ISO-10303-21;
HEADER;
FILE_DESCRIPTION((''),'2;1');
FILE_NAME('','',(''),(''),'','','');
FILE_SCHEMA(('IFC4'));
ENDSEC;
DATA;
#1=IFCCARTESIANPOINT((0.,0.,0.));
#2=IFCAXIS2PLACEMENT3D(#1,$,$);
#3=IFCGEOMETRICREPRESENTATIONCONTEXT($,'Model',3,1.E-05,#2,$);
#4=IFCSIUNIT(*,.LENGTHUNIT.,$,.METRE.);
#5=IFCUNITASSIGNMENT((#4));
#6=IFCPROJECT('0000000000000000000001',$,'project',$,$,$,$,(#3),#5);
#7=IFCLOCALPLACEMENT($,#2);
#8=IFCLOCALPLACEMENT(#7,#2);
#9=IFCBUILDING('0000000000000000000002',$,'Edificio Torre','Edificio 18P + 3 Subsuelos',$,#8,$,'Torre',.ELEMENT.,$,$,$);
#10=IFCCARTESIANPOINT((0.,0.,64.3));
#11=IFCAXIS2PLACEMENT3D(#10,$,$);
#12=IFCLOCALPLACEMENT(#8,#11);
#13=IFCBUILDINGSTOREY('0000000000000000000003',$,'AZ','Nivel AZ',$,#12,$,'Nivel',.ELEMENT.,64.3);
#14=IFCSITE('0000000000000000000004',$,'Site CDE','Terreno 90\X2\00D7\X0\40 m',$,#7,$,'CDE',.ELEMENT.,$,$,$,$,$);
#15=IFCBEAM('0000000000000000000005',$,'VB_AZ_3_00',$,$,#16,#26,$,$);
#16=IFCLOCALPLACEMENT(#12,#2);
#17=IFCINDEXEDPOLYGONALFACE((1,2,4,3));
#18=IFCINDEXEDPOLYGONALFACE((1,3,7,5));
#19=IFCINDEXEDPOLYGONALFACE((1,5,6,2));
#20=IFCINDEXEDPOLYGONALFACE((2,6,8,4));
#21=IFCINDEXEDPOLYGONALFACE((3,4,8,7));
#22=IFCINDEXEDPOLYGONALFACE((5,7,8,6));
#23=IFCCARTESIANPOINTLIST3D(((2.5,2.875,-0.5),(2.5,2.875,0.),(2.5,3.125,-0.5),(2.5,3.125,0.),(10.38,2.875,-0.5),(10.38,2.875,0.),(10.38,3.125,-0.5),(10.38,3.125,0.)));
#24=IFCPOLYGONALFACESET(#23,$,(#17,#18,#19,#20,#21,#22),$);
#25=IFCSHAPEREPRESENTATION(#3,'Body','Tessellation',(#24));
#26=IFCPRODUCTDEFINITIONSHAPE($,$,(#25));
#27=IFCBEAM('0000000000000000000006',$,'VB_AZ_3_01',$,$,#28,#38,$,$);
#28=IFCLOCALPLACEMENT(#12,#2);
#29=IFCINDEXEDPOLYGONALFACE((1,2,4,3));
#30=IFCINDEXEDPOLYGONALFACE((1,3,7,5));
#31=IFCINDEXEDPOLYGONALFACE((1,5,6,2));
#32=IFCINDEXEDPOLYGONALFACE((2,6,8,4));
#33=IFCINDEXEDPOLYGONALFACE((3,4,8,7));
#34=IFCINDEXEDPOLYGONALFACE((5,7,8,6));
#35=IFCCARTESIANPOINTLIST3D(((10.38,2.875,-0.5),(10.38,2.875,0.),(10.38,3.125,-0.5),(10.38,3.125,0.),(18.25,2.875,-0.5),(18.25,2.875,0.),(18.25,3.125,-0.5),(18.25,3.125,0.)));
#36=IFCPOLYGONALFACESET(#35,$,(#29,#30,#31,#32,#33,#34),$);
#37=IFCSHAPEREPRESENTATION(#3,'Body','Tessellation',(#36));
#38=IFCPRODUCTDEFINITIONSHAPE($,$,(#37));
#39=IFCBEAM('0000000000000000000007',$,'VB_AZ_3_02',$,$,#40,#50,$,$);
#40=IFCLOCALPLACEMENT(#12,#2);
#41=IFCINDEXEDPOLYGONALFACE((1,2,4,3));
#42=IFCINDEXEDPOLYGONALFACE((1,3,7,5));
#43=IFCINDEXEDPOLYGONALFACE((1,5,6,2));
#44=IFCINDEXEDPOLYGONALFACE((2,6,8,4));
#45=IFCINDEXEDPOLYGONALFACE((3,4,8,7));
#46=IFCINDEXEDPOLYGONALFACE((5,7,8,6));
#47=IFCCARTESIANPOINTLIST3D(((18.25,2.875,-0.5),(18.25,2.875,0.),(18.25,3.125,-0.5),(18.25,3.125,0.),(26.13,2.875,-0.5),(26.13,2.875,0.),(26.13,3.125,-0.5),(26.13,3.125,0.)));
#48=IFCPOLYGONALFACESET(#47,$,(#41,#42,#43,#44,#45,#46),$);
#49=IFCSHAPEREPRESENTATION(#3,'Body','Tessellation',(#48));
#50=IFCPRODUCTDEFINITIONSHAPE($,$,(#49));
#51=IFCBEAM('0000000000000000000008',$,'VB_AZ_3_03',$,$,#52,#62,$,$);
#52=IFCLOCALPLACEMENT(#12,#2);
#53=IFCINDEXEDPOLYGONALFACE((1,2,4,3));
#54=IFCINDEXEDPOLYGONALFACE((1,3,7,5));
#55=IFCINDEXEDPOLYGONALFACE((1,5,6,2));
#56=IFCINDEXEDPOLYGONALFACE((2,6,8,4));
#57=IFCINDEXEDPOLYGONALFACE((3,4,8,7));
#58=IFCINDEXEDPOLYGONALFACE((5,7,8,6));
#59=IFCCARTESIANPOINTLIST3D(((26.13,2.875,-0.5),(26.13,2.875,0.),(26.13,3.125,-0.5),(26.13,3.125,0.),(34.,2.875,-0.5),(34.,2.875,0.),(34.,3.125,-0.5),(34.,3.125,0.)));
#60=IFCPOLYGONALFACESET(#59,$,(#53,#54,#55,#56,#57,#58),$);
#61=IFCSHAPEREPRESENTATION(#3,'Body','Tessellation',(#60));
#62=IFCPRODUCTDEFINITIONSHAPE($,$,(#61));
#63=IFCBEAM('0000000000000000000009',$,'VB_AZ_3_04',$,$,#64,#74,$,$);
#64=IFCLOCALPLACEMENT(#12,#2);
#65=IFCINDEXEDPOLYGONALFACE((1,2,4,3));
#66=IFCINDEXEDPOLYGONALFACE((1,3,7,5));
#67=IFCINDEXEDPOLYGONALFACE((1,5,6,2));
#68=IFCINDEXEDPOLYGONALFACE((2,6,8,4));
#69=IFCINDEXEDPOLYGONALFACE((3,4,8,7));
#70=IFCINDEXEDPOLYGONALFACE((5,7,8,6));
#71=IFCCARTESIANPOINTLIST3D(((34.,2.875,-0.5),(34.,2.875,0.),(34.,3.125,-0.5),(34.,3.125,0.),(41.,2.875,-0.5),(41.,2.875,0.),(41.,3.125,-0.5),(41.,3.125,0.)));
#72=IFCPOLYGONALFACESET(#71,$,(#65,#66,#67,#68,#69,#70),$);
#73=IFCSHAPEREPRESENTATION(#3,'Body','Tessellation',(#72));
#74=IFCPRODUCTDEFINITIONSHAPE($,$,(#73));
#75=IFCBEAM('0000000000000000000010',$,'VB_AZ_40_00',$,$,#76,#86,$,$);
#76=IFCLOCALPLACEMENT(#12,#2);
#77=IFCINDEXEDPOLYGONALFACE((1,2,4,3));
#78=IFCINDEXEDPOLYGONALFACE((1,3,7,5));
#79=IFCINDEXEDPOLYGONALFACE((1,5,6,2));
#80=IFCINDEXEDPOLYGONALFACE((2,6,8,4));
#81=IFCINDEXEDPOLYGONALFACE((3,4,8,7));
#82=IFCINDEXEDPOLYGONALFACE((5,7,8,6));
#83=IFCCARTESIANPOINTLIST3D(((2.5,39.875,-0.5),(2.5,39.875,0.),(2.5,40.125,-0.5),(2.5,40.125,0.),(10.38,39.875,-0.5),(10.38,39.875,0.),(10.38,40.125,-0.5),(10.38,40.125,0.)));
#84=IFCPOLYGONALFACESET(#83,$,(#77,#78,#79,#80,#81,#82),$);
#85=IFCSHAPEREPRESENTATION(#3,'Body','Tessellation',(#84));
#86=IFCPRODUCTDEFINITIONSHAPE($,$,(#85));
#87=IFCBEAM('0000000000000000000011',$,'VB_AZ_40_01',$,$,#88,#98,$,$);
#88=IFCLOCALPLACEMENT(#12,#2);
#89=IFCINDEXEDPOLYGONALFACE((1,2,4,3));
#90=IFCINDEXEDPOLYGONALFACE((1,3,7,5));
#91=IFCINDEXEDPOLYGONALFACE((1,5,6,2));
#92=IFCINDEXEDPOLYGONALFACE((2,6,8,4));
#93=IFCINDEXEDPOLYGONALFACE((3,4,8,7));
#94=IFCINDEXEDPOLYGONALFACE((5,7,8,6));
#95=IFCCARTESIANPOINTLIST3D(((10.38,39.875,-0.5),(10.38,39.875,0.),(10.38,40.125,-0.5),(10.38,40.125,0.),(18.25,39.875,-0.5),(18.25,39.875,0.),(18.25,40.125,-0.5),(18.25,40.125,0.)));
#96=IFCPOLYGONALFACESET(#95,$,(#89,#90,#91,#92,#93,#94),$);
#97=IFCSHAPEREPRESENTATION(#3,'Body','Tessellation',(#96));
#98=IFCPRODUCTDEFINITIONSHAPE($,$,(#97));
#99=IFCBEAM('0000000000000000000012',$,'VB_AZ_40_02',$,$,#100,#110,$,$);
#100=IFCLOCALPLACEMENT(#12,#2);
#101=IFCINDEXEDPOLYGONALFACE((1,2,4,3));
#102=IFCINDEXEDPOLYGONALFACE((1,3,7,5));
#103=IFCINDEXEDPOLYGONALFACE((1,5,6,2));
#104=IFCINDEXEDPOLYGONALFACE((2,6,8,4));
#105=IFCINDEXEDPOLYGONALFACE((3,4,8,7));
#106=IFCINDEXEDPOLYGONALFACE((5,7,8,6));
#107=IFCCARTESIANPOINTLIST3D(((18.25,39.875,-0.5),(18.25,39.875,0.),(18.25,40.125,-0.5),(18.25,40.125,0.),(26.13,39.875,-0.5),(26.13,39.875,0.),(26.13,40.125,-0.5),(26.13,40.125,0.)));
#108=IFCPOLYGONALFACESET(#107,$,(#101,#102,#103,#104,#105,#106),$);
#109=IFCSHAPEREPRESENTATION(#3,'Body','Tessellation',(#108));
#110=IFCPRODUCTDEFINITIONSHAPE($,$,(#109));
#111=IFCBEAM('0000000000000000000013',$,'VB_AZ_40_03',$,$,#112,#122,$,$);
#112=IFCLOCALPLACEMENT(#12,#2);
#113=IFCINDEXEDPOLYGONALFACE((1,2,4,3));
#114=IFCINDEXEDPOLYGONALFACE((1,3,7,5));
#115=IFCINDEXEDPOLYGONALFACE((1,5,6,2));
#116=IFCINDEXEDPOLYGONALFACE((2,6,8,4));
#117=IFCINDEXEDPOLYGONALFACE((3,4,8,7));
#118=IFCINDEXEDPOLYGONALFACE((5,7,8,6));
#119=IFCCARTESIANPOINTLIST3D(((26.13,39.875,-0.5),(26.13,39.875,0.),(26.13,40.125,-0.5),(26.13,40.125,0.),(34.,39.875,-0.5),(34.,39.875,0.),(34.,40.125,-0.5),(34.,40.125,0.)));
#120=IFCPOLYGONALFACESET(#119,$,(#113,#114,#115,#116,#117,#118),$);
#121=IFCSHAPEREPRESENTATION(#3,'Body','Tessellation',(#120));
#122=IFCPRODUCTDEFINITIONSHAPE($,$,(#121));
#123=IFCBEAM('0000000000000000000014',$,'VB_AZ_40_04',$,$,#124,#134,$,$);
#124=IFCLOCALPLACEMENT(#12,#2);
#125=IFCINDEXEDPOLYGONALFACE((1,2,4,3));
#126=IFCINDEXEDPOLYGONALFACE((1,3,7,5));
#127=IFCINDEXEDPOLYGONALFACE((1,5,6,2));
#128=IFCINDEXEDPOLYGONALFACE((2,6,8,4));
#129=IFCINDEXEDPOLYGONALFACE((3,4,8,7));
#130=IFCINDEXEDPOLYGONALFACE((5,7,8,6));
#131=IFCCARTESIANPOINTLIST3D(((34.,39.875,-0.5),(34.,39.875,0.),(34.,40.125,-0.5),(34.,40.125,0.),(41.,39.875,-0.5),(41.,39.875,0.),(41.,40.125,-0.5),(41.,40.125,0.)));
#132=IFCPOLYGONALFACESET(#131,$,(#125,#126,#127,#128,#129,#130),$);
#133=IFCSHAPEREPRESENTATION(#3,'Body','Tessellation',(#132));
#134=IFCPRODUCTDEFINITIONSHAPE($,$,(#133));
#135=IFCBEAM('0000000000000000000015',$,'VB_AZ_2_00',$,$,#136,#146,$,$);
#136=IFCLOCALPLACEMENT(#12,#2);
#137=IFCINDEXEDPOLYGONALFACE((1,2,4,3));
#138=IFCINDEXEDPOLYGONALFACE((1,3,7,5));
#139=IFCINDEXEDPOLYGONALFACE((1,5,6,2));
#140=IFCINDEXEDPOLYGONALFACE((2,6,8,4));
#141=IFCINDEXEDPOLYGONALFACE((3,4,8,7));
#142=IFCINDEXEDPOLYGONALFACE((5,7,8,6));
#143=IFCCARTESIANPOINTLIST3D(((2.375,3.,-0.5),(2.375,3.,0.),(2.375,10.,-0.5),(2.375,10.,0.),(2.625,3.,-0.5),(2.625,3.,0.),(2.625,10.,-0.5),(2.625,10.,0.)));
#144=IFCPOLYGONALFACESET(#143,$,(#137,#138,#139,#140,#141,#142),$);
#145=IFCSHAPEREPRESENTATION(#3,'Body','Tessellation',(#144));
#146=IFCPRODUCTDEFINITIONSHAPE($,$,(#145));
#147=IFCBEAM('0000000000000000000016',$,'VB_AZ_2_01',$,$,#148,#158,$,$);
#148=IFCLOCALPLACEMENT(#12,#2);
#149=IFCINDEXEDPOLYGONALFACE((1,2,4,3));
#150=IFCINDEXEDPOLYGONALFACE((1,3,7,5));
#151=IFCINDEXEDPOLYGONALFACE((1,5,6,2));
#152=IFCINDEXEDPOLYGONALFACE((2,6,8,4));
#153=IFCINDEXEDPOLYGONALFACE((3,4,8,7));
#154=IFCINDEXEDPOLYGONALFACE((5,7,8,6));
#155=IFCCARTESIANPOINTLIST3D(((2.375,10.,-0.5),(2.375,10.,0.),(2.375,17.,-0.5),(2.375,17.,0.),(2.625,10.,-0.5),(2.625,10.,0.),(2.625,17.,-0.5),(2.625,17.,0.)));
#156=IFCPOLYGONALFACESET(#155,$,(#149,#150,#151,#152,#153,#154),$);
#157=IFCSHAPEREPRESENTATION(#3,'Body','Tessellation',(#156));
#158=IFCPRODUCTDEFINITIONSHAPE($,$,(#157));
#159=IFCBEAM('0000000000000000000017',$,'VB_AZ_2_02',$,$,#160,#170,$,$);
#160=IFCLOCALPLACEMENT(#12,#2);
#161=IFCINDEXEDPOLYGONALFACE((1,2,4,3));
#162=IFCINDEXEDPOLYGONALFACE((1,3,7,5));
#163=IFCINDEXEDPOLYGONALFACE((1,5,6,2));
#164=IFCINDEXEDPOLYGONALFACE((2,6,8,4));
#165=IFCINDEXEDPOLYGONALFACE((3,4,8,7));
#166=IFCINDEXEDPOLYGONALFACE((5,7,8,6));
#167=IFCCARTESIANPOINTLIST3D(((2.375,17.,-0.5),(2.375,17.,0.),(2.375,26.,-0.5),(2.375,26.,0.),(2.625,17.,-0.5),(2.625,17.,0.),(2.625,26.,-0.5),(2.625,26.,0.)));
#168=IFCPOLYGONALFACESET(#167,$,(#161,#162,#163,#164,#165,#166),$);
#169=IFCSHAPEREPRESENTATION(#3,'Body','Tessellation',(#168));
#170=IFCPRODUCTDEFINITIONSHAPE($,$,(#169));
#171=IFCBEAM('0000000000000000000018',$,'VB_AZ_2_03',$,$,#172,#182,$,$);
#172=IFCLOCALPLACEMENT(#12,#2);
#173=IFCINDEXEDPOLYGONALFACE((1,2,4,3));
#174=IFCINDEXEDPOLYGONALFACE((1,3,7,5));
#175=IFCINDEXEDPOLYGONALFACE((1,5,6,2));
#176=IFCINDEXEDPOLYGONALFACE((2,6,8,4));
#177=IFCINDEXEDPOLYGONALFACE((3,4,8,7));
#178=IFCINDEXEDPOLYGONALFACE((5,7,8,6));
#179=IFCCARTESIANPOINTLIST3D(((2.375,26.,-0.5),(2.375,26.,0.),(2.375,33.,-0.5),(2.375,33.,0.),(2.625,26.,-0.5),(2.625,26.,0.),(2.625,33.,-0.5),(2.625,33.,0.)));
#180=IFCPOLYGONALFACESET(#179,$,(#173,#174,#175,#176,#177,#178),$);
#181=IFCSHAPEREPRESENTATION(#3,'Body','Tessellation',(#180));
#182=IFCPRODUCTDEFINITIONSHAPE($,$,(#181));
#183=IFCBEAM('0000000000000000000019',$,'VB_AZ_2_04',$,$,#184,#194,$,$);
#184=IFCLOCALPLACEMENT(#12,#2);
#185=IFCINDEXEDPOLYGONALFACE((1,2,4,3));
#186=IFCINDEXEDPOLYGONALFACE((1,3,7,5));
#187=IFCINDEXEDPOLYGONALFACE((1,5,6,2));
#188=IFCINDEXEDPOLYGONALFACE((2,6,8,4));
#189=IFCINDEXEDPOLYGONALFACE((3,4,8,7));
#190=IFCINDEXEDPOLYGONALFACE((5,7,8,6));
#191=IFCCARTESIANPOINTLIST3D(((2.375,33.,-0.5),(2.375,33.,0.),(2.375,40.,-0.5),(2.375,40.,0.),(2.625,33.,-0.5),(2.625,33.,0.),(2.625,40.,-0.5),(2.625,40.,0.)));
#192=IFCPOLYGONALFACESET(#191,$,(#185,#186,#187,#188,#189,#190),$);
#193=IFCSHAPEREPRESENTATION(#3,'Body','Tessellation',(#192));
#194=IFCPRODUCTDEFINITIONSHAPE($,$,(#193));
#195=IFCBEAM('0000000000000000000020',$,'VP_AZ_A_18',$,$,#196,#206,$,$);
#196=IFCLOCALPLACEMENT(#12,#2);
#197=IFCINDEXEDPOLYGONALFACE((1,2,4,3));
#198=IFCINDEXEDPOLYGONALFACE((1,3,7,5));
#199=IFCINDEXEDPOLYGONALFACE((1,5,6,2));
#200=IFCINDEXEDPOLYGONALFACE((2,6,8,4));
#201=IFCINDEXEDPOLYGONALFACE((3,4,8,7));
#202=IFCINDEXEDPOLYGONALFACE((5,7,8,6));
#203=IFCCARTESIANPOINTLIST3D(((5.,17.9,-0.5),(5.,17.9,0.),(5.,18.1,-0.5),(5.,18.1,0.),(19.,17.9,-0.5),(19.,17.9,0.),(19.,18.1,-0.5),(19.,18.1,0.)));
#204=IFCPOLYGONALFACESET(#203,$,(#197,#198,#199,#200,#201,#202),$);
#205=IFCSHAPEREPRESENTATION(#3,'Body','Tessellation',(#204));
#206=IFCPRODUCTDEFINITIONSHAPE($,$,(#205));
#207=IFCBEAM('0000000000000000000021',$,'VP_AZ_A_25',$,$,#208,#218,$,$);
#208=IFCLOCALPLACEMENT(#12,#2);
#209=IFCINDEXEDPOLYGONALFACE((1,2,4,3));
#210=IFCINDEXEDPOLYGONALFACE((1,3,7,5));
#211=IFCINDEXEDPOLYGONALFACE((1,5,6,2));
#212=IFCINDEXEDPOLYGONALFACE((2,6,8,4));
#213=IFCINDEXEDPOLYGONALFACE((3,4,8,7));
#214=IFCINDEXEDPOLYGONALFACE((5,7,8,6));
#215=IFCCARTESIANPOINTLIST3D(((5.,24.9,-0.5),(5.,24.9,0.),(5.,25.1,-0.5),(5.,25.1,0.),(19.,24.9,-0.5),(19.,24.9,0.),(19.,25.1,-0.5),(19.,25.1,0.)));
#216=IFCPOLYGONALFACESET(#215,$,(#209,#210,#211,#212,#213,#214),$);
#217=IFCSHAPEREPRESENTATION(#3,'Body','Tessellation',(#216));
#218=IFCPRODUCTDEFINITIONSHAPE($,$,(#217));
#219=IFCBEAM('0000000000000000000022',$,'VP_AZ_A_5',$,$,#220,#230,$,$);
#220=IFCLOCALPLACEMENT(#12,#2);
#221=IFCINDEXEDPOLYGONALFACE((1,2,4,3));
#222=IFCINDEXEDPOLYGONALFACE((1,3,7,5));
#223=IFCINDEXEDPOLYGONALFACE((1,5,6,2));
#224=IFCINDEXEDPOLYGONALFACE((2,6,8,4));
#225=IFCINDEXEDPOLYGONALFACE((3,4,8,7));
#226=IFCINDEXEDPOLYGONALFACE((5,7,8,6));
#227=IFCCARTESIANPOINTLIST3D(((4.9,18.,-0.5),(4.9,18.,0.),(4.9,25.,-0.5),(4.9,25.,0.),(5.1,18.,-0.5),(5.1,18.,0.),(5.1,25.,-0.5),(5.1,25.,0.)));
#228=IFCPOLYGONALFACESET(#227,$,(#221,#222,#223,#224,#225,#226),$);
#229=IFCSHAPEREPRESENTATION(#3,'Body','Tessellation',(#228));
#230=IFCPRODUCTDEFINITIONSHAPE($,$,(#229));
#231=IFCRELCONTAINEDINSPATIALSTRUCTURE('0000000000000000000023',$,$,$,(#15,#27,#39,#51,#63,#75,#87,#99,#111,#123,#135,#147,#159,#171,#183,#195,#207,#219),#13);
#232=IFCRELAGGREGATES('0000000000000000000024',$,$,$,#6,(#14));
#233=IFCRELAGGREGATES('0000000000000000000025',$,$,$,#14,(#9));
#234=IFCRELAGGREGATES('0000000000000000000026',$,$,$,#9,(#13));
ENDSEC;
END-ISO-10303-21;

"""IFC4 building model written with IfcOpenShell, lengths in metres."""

from ifc_helpers import new_model, si_unit, frame, origin, origin_2d, place, context, project, spatial, rectangle, extrude, element, save


model = new_model("IFC4")

# Units and contexts
model_context = context("Model", 3, precision=1e-05, world=origin())
ifc_project = project(units=[si_unit("LENGTHUNIT", "METRE")], contexts=[model_context])

# Site, building, storey
site_placement = place(None, origin())
site = spatial("IfcSite", under=ifc_project, at=site_placement, Name="Site CDE", Description="Terreno 90×40 m", LongName="CDE", CompositionType="ELEMENT")
building_placement = place(site_placement, origin())
building = spatial("IfcBuilding", under=site, at=building_placement, Name="Edificio Torre", Description="Edificio 18P + 3 Subsuelos", LongName="Torre", CompositionType="ELEMENT")
storey_placement = place(building_placement, frame((0.0, 0.0, 64.3)))
storey = spatial("IfcBuildingStorey", under=building, at=storey_placement, Name="AZ", Description="Nivel AZ", LongName="Nivel", CompositionType="ELEMENT", Elevation=64.3)

# Beams
beam_1_placement = place(storey_placement, frame((6.44, 3.0, -0.5)))
element("IfcBeam", 1, at=beam_1_placement, inside=storey, Name="VB_AZ_3_00", context=model_context, shape_type="SweptSolid", body=[
    extrude(rectangle(XDim=7.88, YDim=0.25, at=origin_2d()), origin(), (0.0, 0.0, 1.0), 0.5),
])
beam_2_placement = place(storey_placement, frame((14.315, 3.0, -0.5)))
element("IfcBeam", 2, at=beam_2_placement, inside=storey, Name="VB_AZ_3_01", context=model_context, shape_type="SweptSolid", body=[
    extrude(rectangle(XDim=7.87, YDim=0.25, at=origin_2d()), origin(), (0.0, 0.0, 1.0), 0.5),
])
beam_3_placement = place(storey_placement, frame((22.19, 3.0, -0.5)))
element("IfcBeam", 3, at=beam_3_placement, inside=storey, Name="VB_AZ_3_02", context=model_context, shape_type="SweptSolid", body=[
    extrude(rectangle(XDim=7.88, YDim=0.25, at=origin_2d()), origin(), (0.0, 0.0, 1.0), 0.5),
])
beam_4_placement = place(storey_placement, frame((30.065, 3.0, -0.5)))
element("IfcBeam", 4, at=beam_4_placement, inside=storey, Name="VB_AZ_3_03", context=model_context, shape_type="SweptSolid", body=[
    extrude(rectangle(XDim=7.87, YDim=0.25, at=origin_2d()), origin(), (0.0, 0.0, 1.0), 0.5),
])
beam_5_placement = place(storey_placement, frame((37.5, 3.0, -0.5)))
element("IfcBeam", 5, at=beam_5_placement, inside=storey, Name="VB_AZ_3_04", context=model_context, shape_type="SweptSolid", body=[
    extrude(rectangle(XDim=7.0, YDim=0.25, at=origin_2d()), origin(), (0.0, 0.0, 1.0), 0.5),
])
beam_6_placement = place(storey_placement, frame((6.44, 40.0, -0.5)))
element("IfcBeam", 6, at=beam_6_placement, inside=storey, Name="VB_AZ_40_00", context=model_context, shape_type="SweptSolid", body=[
    extrude(rectangle(XDim=7.88, YDim=0.25, at=origin_2d()), origin(), (0.0, 0.0, 1.0), 0.5),
])
beam_7_placement = place(storey_placement, frame((14.315, 40.0, -0.5)))
element("IfcBeam", 7, at=beam_7_placement, inside=storey, Name="VB_AZ_40_01", context=model_context, shape_type="SweptSolid", body=[
    extrude(rectangle(XDim=7.87, YDim=0.25, at=origin_2d()), origin(), (0.0, 0.0, 1.0), 0.5),
])
beam_8_placement = place(storey_placement, frame((22.19, 40.0, -0.5)))
element("IfcBeam", 8, at=beam_8_placement, inside=storey, Name="VB_AZ_40_02", context=model_context, shape_type="SweptSolid", body=[
    extrude(rectangle(XDim=7.88, YDim=0.25, at=origin_2d()), origin(), (0.0, 0.0, 1.0), 0.5),
])
beam_9_placement = place(storey_placement, frame((30.065, 40.0, -0.5)))
element("IfcBeam", 9, at=beam_9_placement, inside=storey, Name="VB_AZ_40_03", context=model_context, shape_type="SweptSolid", body=[
    extrude(rectangle(XDim=7.87, YDim=0.25, at=origin_2d()), origin(), (0.0, 0.0, 1.0), 0.5),
])
beam_10_placement = place(storey_placement, frame((37.5, 40.0, -0.5)))
element("IfcBeam", 10, at=beam_10_placement, inside=storey, Name="VB_AZ_40_04", context=model_context, shape_type="SweptSolid", body=[
    extrude(rectangle(XDim=7.0, YDim=0.25, at=origin_2d()), origin(), (0.0, 0.0, 1.0), 0.5),
])
for number, where, name in (
    (11, (2.5, 6.5, -0.5), "VB_AZ_2_00"),
    (12, (2.5, 13.5, -0.5), "VB_AZ_2_01"),
):
    element("IfcBeam", number, at=place(storey_placement, frame(where)), inside=storey, Name=name, context=model_context, shape_type="SweptSolid", body=[
        extrude(rectangle(XDim=0.25, YDim=7.0, at=origin_2d()), origin(), (0.0, 0.0, 1.0), 0.5),
    ])
beam_11_placement = place(storey_placement, frame((2.5, 21.5, -0.5)))
element("IfcBeam", 13, at=beam_11_placement, inside=storey, Name="VB_AZ_2_02", context=model_context, shape_type="SweptSolid", body=[
    extrude(rectangle(XDim=0.25, YDim=9.0, at=origin_2d()), origin(), (0.0, 0.0, 1.0), 0.5),
])
for number, where, name in (
    (14, (2.5, 29.5, -0.5), "VB_AZ_2_03"),
    (15, (2.5, 36.5, -0.5), "VB_AZ_2_04"),
):
    element("IfcBeam", number, at=place(storey_placement, frame(where)), inside=storey, Name=name, context=model_context, shape_type="SweptSolid", body=[
        extrude(rectangle(XDim=0.25, YDim=7.0, at=origin_2d()), origin(), (0.0, 0.0, 1.0), 0.5),
    ])
for number, where, name in (
    (16, (12.0, 18.0, -0.5), "VP_AZ_A_18"),
    (17, (12.0, 25.0, -0.5), "VP_AZ_A_25"),
):
    element("IfcBeam", number, at=place(storey_placement, frame(where)), inside=storey, Name=name, context=model_context, shape_type="SweptSolid", body=[
        extrude(rectangle(XDim=14.0, YDim=0.2, at=origin_2d()), origin(), (0.0, 0.0, 1.0), 0.5),
    ])
beam_12_placement = place(storey_placement, frame((5.0, 21.5, -0.5)))
element("IfcBeam", 18, at=beam_12_placement, inside=storey, Name="VP_AZ_A_5", context=model_context, shape_type="SweptSolid", body=[
    extrude(rectangle(XDim=0.2, YDim=7.0, at=origin_2d()), origin(), (0.0, 0.0, 1.0), 0.5),
])

save(model, "model.ifc")
